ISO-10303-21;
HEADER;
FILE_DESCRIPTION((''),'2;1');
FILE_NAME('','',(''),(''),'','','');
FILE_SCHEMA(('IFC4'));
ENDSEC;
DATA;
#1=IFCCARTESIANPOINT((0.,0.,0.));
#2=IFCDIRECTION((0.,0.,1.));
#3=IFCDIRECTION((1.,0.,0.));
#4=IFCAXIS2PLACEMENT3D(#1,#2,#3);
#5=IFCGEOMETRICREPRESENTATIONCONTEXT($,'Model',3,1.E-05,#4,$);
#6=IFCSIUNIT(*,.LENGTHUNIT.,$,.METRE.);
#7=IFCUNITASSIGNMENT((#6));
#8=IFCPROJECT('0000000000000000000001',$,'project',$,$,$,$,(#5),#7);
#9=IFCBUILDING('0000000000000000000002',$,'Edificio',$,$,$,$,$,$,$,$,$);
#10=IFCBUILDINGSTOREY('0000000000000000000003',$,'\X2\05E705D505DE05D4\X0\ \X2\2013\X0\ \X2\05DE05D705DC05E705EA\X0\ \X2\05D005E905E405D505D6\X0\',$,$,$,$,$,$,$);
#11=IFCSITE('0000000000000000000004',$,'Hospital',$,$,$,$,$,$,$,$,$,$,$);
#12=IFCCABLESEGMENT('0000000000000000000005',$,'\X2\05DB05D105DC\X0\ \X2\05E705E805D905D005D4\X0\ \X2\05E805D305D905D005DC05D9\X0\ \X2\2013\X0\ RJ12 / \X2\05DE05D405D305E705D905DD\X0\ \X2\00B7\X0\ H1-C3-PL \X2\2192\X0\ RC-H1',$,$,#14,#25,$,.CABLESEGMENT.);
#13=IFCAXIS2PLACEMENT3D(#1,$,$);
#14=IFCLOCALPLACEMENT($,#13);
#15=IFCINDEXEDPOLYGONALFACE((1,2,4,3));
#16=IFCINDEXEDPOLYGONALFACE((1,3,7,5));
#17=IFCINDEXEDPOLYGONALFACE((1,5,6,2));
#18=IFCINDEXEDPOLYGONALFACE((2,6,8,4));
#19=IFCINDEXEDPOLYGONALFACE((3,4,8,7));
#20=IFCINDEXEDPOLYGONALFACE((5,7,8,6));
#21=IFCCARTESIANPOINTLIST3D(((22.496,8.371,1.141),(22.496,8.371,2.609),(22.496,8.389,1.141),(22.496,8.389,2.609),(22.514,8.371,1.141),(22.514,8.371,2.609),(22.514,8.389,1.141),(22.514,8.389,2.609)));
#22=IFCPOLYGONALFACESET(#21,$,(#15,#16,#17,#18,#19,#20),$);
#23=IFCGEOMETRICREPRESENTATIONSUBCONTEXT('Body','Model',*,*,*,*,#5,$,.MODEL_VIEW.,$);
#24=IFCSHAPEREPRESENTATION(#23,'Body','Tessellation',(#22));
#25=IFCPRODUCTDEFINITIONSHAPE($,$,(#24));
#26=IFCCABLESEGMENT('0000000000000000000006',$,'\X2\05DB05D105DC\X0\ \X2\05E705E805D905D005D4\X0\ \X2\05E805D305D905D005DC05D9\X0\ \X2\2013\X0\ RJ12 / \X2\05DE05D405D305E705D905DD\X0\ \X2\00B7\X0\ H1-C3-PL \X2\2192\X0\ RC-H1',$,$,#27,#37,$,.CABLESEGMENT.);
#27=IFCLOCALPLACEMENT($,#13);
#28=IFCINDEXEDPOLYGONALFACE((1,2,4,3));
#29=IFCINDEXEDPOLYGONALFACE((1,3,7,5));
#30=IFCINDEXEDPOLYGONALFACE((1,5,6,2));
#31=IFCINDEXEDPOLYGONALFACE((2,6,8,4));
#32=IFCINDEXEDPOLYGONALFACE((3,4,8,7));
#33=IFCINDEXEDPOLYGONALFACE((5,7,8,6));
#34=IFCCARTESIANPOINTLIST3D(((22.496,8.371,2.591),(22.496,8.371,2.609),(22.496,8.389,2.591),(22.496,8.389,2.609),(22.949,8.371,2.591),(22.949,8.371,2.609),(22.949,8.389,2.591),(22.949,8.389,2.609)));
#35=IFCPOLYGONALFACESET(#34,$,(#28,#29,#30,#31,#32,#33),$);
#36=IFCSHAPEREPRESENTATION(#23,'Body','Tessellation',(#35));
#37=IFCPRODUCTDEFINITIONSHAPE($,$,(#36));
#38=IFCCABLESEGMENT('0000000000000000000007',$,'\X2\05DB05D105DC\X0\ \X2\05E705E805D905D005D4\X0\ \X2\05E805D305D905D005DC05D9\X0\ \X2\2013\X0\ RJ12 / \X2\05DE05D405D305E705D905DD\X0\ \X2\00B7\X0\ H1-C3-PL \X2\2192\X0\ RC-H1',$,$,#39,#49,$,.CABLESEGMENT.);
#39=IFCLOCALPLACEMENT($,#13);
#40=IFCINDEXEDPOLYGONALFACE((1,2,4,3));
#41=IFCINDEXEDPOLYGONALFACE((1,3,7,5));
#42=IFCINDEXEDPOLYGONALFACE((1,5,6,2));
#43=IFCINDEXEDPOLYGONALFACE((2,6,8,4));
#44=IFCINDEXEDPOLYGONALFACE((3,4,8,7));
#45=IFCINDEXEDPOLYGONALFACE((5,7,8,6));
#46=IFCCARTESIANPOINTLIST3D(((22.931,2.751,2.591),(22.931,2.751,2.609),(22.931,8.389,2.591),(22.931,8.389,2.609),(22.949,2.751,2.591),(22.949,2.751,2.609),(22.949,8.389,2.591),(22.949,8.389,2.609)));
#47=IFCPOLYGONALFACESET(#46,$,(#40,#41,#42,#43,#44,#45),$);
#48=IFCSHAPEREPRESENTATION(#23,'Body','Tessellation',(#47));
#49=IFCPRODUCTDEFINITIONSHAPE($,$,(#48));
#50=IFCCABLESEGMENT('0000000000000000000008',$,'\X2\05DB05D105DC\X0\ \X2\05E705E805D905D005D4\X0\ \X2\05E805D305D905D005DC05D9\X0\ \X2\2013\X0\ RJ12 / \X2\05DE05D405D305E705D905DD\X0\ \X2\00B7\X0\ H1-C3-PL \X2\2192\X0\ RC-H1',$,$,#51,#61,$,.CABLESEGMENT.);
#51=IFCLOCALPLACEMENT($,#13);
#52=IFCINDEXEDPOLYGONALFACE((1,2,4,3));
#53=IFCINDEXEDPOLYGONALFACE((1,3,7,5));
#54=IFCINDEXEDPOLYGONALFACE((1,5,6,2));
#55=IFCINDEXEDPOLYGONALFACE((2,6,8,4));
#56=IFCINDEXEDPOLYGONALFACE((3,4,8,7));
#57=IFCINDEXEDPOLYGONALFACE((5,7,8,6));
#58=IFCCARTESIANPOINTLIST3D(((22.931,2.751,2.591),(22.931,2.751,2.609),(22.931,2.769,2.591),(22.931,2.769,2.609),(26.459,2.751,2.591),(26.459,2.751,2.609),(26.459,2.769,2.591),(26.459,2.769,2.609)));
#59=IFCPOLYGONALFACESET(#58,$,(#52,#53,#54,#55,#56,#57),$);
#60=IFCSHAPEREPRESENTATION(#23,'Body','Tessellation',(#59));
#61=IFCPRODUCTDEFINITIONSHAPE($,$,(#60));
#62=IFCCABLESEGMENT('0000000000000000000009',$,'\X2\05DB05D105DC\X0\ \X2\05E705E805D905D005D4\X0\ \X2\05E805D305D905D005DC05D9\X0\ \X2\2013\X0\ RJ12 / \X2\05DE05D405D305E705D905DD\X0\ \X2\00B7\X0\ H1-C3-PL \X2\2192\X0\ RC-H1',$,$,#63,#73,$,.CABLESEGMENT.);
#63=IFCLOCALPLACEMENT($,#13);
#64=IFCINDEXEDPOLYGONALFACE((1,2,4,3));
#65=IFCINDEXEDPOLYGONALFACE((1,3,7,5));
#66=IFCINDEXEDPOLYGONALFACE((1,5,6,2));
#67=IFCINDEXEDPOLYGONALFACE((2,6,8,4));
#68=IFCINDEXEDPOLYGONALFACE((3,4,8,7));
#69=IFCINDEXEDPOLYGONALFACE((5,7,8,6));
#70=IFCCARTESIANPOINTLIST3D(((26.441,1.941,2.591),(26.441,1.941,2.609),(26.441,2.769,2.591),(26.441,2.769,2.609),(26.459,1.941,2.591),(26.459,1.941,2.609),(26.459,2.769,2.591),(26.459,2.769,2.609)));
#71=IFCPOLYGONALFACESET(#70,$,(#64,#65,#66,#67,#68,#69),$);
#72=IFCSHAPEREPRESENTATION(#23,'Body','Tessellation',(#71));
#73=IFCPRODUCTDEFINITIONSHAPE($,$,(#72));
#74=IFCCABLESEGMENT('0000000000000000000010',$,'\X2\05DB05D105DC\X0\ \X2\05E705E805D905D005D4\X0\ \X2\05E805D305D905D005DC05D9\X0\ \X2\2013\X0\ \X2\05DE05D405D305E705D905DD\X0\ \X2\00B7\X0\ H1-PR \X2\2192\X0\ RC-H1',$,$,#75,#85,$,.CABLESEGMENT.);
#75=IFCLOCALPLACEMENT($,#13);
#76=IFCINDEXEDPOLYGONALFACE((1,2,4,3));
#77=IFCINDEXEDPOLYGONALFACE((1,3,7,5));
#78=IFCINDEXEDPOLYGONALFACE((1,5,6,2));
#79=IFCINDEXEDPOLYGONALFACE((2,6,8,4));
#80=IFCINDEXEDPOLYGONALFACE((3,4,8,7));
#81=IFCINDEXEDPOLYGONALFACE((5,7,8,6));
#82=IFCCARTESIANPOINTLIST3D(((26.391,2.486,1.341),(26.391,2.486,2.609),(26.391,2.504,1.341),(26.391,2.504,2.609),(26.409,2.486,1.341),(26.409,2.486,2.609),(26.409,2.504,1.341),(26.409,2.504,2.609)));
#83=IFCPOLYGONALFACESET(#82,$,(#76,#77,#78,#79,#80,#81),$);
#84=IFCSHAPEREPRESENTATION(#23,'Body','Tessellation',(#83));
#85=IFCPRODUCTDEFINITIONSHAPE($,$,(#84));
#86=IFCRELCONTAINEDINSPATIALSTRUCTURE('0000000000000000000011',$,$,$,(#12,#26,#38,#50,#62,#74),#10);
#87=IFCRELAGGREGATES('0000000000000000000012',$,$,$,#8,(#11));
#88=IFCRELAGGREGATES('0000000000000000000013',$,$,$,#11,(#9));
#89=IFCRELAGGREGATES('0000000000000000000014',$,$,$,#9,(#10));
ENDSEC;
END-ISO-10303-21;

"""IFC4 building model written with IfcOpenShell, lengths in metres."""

from ifc_helpers import new_model, si_unit, frame, origin_with_axes, context, subcontext, project, spatial, line, indexed_curve, outline, extrude, element, save


model = new_model("IFC4")

# Units and contexts
model_context = context("Model", 3, precision=1e-05, world=origin_with_axes())
body_context = subcontext(model_context, "Body", "Model", "MODEL_VIEW")
ifc_project = project(units=[si_unit("LENGTHUNIT", "METRE")], contexts=[model_context])

# Site, building, storey
site = spatial("IfcSite", under=ifc_project, Name="Hospital")
building = spatial("IfcBuilding", under=site, Name="Edificio")
storey = spatial("IfcBuildingStorey", under=building, Name="קומה – מחלקת אשפוז")

# Cable segments
element("IfcCableSegment", 1, inside=storey, Name="כבל קריאה רדיאלי – RJ12 / מהדקים · H1-C3-PL → RC-H1", PredefinedType="CABLESEGMENT", context=body_context, shape_type="SweptSolid", body=[
    extrude(outline(indexed_curve([(0.0, 0.0), (0.018, 0.0), (0.018, 0.018), (0.0, 0.018)], segments=[line(1, 2, 3, 4, 1)])), frame((22.496, 8.371, 1.141), z_axis=(0.0, 0.0, 1.0), x_axis=(1.0, 0.0, 0.0)), (0.0, 0.0, 1.0), 1.468),
])
element("IfcCableSegment", 2, inside=storey, Name="כבל קריאה רדיאלי – RJ12 / מהדקים · H1-C3-PL → RC-H1", PredefinedType="CABLESEGMENT", context=body_context, shape_type="SweptSolid", body=[
    extrude(outline(indexed_curve([(0.0, 0.0), (0.453, 0.0), (0.453, 0.018), (0.0, 0.018)], segments=[line(1, 2, 3, 4, 1)])), frame((22.496, 8.371, 2.591), z_axis=(0.0, 0.0, 1.0), x_axis=(1.0, 0.0, 0.0)), (0.0, 0.0, 1.0), 0.018),
])
element("IfcCableSegment", 3, inside=storey, Name="כבל קריאה רדיאלי – RJ12 / מהדקים · H1-C3-PL → RC-H1", PredefinedType="CABLESEGMENT", context=body_context, shape_type="SweptSolid", body=[
    extrude(outline(indexed_curve([(0.0, 0.0), (0.018, 0.0), (0.018, 5.638), (0.0, 5.638)], segments=[line(1, 2, 3, 4, 1)])), frame((22.931, 2.751, 2.591), z_axis=(0.0, 0.0, 1.0), x_axis=(1.0, 0.0, 0.0)), (0.0, 0.0, 1.0), 0.018),
])
element("IfcCableSegment", 4, inside=storey, Name="כבל קריאה רדיאלי – RJ12 / מהדקים · H1-C3-PL → RC-H1", PredefinedType="CABLESEGMENT", context=body_context, shape_type="SweptSolid", body=[
    extrude(outline(indexed_curve([(0.0, 0.0), (3.528, 0.0), (3.528, 0.018), (0.0, 0.018)], segments=[line(1, 2, 3, 4, 1)])), frame((22.931, 2.751, 2.591), z_axis=(0.0, 0.0, 1.0), x_axis=(1.0, 0.0, 0.0)), (0.0, 0.0, 1.0), 0.018),
])
element("IfcCableSegment", 5, inside=storey, Name="כבל קריאה רדיאלי – RJ12 / מהדקים · H1-C3-PL → RC-H1", PredefinedType="CABLESEGMENT", context=body_context, shape_type="SweptSolid", body=[
    extrude(outline(indexed_curve([(0.0, 0.0), (0.018, 0.0), (0.018, 0.828), (0.0, 0.828)], segments=[line(1, 2, 3, 4, 1)])), frame((26.441, 1.941, 2.591), z_axis=(0.0, 0.0, 1.0), x_axis=(1.0, 0.0, 0.0)), (0.0, 0.0, 1.0), 0.018),
])
element("IfcCableSegment", 6, inside=storey, Name="כבל קריאה רדיאלי – מהדקים · H1-PR → RC-H1", PredefinedType="CABLESEGMENT", context=body_context, shape_type="SweptSolid", body=[
    extrude(outline(indexed_curve([(0.0, 0.0), (0.018, 0.0), (0.018, 0.018), (0.0, 0.018)], segments=[line(1, 2, 3, 4, 1)])), frame((26.391, 2.486, 1.341), z_axis=(0.0, 0.0, 1.0), x_axis=(1.0, 0.0, 0.0)), (0.0, 0.0, 1.0), 1.268),
])

save(model, "model.ifc")
